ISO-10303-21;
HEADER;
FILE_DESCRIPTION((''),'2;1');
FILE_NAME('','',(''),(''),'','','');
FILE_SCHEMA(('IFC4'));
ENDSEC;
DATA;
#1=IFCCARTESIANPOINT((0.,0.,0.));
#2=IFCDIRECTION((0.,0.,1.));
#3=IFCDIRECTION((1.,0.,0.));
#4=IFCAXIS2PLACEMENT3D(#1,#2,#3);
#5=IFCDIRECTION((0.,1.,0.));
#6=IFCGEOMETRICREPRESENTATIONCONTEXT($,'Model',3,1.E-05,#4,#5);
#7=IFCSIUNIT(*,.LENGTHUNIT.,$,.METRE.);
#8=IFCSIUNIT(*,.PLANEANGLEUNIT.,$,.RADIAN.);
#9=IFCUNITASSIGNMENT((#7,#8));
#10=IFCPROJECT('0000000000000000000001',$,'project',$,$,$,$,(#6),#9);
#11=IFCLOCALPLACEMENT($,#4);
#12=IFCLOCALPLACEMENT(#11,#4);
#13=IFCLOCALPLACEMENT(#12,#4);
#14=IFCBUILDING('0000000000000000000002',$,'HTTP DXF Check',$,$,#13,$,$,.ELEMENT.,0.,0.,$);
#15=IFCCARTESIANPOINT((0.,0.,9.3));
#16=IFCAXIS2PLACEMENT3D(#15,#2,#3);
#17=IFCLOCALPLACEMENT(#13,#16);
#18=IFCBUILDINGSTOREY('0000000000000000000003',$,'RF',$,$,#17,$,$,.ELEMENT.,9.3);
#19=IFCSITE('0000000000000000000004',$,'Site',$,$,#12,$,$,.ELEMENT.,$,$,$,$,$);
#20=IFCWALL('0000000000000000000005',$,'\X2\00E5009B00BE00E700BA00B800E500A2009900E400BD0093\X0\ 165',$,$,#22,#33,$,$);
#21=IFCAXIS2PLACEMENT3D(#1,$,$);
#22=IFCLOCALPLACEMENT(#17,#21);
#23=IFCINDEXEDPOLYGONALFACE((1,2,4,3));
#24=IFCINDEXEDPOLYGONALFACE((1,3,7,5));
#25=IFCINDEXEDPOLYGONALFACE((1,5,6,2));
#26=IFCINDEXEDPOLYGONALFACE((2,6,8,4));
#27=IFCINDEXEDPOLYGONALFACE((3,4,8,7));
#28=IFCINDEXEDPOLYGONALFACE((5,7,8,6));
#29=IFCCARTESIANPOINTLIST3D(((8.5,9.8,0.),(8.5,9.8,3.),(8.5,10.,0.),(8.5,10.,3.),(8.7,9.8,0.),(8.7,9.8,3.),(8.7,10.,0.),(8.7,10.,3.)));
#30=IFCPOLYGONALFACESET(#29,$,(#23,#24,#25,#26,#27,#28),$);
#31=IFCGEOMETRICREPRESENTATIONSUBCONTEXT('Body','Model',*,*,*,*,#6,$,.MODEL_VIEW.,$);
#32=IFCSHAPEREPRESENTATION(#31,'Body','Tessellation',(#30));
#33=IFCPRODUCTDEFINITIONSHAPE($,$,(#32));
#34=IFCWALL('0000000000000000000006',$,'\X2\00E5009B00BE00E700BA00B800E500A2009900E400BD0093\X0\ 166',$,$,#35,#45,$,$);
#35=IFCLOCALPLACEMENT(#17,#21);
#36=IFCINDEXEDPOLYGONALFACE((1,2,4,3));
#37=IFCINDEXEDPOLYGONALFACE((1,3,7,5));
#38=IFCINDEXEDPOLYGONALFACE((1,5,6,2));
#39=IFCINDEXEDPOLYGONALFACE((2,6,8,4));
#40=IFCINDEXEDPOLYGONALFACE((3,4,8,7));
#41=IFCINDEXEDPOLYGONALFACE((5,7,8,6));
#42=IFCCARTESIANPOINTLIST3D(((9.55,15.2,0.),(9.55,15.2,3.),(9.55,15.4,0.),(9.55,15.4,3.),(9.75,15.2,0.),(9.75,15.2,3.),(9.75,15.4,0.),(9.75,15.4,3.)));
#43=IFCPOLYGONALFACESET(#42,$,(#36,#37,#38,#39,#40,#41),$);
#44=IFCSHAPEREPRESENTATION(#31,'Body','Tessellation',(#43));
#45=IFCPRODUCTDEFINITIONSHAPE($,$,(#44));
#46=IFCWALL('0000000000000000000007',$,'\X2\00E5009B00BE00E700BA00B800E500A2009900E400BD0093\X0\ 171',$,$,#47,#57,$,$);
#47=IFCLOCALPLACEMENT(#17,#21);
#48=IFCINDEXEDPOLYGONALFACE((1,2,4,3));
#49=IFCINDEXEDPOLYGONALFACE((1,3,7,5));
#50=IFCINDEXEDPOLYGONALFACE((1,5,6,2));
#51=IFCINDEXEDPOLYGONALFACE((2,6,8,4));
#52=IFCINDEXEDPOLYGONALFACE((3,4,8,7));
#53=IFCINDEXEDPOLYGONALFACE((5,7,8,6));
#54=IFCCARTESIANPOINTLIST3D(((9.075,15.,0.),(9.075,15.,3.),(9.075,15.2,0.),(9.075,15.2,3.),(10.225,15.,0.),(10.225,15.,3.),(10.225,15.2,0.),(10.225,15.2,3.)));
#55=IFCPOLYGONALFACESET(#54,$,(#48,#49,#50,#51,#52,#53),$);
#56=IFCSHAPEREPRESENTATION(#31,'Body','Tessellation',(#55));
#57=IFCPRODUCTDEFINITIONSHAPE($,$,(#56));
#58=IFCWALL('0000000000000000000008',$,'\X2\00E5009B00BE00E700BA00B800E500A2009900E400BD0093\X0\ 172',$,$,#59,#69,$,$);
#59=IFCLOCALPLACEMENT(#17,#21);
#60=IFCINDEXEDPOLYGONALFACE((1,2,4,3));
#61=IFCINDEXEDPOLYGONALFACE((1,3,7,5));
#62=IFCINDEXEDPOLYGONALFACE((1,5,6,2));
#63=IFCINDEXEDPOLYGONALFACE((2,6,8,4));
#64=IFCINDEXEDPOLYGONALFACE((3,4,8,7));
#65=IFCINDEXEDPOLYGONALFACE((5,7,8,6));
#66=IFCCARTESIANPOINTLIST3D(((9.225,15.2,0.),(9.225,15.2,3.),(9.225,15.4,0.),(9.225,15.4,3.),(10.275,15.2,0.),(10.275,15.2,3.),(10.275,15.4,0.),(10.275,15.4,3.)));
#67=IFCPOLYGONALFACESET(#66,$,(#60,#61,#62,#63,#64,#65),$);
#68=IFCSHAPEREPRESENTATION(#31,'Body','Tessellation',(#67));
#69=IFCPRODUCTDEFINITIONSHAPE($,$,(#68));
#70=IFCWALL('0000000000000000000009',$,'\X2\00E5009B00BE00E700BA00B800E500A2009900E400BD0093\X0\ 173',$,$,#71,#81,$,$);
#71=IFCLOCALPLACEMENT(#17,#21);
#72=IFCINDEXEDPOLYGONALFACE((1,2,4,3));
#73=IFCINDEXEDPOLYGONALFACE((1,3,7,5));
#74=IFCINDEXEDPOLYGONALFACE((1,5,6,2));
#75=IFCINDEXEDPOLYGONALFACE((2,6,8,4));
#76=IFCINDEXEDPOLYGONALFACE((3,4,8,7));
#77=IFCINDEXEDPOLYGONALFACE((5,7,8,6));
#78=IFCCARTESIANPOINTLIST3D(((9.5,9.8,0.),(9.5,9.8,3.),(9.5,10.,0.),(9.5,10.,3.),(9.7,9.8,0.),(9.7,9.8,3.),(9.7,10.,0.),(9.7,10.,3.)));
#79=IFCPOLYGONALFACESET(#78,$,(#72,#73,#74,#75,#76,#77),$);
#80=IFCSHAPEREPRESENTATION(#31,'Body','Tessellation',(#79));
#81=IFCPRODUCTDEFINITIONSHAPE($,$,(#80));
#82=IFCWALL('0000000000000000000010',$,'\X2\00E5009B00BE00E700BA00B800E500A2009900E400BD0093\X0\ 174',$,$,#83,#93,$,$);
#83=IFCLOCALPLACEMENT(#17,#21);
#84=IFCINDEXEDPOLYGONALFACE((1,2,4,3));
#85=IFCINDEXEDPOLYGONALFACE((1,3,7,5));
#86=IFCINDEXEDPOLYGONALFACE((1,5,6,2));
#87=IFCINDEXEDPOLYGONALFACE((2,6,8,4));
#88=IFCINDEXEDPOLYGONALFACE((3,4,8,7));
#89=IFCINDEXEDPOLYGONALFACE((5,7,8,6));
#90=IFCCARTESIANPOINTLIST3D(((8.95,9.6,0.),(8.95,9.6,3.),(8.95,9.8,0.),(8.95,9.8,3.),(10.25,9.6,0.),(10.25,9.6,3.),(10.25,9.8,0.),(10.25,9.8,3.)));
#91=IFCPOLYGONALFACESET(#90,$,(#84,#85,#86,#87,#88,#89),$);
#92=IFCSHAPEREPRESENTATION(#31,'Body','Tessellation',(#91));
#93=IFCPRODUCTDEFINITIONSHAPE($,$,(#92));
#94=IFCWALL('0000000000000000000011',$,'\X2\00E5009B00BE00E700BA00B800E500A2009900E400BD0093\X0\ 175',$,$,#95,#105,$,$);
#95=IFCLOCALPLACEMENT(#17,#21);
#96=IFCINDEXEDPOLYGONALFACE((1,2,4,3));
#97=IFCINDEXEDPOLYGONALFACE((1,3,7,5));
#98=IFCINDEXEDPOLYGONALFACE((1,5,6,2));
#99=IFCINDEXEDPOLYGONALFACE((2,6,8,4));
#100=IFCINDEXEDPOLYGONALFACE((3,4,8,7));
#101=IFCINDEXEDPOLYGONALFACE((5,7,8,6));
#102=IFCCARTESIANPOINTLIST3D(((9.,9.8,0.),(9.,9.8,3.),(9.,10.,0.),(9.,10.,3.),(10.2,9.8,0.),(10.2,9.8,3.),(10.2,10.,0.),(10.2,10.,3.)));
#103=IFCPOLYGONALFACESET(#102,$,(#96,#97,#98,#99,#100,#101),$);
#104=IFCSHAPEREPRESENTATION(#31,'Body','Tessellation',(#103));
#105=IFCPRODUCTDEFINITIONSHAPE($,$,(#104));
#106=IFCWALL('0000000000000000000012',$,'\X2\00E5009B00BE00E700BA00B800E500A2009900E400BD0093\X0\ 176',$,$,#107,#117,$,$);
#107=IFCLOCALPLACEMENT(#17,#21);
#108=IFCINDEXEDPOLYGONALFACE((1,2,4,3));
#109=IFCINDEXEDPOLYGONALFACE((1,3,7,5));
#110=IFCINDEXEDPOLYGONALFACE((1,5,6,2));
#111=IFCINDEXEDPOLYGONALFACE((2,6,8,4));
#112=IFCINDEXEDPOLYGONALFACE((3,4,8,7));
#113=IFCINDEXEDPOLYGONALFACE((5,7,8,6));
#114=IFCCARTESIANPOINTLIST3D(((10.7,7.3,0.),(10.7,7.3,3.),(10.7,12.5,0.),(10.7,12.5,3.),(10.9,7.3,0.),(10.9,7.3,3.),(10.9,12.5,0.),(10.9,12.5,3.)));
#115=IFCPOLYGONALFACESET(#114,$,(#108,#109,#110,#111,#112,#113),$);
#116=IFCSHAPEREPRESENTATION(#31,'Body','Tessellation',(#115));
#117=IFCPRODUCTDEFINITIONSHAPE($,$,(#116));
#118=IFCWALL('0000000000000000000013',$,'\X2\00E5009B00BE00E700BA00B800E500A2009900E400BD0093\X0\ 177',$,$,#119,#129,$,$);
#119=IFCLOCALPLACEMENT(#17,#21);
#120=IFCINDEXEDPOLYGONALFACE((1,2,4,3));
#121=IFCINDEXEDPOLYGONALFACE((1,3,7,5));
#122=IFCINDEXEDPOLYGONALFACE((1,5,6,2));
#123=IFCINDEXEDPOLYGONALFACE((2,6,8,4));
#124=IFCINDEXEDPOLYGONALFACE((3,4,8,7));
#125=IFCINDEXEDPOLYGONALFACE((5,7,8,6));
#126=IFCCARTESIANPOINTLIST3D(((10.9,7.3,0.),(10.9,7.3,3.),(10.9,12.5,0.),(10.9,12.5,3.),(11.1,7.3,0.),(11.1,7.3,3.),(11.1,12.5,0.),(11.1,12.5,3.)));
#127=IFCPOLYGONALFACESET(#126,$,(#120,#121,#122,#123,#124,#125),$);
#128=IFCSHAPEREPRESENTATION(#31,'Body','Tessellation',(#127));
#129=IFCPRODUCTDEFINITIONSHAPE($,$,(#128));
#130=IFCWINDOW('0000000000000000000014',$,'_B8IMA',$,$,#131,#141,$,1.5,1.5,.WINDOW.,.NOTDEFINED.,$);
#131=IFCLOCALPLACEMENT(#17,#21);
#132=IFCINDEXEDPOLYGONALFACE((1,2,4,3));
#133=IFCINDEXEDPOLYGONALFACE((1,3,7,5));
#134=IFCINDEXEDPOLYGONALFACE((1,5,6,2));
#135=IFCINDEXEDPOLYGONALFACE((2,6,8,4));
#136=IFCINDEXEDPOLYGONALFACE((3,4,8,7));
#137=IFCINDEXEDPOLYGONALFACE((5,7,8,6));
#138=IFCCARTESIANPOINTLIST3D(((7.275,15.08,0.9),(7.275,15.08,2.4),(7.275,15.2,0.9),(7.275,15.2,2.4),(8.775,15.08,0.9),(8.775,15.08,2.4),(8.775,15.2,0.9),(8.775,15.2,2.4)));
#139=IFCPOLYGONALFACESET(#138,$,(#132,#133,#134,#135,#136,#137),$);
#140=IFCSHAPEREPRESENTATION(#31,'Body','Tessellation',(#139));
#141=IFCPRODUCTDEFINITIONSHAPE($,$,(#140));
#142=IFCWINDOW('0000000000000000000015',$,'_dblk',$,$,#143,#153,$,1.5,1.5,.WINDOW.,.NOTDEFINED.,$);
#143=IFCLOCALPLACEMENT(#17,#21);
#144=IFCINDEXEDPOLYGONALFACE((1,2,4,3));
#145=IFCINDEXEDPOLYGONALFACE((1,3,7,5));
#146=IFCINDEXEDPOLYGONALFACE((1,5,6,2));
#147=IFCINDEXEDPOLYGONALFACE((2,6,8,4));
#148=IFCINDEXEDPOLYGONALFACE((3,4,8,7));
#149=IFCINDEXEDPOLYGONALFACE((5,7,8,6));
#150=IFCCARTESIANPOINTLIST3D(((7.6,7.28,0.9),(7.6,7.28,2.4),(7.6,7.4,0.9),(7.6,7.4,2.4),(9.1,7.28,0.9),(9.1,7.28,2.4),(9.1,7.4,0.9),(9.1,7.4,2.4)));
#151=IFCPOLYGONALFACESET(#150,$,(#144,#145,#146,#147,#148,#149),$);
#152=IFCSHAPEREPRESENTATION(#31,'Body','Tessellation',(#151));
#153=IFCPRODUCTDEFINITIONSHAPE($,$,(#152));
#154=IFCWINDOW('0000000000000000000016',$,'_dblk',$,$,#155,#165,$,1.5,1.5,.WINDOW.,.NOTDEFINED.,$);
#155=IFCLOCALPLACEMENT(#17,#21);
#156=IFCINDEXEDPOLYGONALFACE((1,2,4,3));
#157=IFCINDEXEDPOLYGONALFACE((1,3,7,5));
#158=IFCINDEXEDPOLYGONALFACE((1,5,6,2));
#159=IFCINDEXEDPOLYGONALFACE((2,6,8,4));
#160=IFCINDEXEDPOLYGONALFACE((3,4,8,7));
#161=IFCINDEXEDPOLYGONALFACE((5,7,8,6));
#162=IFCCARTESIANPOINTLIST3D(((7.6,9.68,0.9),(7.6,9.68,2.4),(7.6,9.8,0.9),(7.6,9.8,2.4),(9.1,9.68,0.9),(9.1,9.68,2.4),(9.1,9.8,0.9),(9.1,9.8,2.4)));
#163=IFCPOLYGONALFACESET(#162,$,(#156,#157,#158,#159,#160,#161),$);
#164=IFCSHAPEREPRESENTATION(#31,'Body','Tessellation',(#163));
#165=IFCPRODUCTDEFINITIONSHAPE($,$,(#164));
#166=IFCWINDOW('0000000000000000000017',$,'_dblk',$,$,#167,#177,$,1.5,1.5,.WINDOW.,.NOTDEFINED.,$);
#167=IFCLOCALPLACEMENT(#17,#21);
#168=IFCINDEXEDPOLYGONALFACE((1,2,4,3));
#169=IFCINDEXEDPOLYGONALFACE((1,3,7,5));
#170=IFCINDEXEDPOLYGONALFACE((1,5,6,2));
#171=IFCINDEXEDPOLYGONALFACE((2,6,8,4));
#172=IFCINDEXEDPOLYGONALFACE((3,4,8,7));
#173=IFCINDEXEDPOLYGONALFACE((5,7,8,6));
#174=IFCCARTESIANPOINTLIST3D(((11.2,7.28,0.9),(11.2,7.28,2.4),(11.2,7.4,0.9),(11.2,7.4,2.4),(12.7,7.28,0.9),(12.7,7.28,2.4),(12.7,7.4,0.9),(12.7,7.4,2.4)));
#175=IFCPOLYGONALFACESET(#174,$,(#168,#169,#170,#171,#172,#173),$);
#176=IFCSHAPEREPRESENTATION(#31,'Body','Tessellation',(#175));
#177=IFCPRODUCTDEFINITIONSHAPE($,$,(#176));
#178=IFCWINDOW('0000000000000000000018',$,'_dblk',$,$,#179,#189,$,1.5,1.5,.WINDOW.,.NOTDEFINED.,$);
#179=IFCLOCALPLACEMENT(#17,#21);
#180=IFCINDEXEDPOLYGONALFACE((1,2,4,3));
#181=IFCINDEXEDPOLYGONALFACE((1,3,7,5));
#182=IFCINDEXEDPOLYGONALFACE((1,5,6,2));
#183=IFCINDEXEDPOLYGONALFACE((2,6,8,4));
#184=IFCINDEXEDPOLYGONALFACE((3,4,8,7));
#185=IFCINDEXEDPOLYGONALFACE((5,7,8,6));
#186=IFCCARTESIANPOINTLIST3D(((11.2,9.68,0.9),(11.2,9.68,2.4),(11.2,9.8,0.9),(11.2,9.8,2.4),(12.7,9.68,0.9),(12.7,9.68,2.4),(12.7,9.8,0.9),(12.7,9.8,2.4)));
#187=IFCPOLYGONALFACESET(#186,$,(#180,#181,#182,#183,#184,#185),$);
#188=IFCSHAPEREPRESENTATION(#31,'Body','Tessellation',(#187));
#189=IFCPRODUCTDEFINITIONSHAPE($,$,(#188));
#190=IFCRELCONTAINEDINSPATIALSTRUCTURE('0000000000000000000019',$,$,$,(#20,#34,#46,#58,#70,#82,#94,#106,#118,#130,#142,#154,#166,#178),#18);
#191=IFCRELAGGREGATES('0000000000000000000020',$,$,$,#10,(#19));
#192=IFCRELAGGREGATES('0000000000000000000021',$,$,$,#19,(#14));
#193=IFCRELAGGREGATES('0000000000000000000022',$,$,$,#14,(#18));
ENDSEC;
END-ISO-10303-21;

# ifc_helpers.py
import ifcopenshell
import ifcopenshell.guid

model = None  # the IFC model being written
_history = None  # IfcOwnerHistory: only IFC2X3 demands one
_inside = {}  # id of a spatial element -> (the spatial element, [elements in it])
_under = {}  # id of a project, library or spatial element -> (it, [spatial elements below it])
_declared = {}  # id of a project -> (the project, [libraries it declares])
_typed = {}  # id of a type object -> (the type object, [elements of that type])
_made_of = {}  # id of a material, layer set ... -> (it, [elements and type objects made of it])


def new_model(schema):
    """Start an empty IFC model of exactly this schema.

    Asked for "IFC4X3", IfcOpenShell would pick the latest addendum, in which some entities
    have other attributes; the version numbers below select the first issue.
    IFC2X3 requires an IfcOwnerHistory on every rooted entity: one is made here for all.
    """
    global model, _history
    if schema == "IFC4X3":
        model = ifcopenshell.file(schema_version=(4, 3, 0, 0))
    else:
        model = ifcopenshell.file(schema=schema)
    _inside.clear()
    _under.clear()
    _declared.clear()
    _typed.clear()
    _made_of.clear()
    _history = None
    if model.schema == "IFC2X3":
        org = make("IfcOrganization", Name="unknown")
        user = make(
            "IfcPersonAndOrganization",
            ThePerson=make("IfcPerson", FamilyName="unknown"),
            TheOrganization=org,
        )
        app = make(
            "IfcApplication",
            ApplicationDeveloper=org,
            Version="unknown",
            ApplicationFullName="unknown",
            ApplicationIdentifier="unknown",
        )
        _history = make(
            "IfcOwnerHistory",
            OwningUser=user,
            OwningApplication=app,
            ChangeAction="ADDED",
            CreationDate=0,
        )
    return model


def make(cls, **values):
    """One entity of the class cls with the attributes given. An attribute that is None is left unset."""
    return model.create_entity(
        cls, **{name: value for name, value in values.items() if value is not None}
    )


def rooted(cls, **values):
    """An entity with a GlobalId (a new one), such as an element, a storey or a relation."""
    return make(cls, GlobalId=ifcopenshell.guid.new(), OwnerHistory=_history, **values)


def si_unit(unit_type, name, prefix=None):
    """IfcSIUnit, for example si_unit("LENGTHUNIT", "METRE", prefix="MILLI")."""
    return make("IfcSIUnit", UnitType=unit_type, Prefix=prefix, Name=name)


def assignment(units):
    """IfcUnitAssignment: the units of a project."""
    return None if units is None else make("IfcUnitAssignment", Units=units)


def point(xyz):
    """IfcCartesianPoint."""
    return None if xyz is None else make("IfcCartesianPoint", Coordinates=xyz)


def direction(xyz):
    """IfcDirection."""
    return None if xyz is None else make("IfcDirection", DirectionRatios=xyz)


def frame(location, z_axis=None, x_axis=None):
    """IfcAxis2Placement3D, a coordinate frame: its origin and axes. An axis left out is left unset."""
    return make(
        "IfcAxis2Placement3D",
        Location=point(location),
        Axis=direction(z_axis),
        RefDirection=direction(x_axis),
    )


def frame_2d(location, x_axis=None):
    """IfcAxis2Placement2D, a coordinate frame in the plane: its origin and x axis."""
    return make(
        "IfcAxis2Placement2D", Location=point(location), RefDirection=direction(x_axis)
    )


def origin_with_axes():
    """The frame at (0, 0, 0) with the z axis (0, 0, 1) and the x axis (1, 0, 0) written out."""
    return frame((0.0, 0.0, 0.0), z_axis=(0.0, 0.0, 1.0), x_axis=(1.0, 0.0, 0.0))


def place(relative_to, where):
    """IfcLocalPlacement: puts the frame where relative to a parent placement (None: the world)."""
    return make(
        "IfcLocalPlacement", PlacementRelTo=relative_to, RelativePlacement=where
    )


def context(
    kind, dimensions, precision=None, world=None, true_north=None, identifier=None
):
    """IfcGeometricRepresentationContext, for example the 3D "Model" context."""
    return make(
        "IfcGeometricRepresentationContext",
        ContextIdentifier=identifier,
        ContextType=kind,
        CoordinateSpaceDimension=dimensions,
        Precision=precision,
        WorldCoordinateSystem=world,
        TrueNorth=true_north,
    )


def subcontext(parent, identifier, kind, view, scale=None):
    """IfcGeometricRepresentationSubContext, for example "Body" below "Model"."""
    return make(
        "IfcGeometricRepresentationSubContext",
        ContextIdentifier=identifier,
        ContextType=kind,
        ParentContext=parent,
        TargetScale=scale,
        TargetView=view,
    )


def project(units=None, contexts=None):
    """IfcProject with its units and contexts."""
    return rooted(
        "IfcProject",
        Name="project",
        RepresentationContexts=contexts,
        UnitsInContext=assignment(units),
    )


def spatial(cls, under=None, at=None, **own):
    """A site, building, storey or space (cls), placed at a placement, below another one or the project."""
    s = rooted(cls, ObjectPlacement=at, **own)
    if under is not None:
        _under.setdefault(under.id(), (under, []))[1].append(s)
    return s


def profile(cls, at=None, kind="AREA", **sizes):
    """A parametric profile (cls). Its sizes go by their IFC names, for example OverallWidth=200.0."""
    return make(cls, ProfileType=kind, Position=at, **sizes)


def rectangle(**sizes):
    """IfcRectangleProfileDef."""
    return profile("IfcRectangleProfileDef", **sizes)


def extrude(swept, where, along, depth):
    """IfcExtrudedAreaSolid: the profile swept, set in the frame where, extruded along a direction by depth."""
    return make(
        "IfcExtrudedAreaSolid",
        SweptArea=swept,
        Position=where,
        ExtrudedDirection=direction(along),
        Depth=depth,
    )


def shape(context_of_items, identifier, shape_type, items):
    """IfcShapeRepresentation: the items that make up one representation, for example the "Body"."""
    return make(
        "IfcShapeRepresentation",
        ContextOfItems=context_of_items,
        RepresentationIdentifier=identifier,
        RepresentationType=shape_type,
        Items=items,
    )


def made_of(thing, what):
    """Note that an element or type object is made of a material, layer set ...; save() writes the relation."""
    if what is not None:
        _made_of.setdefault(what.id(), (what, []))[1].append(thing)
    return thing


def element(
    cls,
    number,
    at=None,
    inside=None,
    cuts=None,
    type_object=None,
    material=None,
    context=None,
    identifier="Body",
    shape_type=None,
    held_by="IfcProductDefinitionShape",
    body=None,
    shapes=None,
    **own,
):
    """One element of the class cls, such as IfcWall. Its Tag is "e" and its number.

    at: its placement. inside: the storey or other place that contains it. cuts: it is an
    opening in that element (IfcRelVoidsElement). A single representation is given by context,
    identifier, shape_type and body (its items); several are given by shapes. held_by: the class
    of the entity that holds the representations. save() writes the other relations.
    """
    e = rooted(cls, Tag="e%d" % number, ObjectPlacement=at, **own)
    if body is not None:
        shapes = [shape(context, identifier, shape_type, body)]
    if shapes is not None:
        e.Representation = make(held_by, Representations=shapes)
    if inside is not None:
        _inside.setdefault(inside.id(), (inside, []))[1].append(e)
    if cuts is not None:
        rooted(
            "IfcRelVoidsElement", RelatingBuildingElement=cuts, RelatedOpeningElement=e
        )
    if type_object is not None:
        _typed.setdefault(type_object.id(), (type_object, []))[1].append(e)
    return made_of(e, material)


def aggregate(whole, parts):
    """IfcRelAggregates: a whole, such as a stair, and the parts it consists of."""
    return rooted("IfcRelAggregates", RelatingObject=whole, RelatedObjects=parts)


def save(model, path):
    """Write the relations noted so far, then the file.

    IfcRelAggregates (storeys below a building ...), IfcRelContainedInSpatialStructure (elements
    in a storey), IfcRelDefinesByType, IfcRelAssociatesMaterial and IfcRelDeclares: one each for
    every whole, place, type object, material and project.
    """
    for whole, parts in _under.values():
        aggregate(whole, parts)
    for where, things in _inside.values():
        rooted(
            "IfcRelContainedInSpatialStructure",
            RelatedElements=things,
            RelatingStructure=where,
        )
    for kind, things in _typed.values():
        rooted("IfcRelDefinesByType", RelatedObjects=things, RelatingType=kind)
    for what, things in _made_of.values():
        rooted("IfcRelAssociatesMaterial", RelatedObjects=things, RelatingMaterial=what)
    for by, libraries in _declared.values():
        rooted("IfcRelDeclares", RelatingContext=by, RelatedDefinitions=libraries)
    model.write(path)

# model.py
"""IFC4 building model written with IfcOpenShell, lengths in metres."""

from ifc_helpers import new_model, si_unit, direction, frame, frame_2d, origin_with_axes, place, context, subcontext, project, spatial, rectangle, extrude, element, save


model = new_model("IFC4")

# Units and contexts
model_context = context("Model", 3, precision=1e-05, world=origin_with_axes(), true_north=direction((0.0, 1.0, 0.0)))
body_context = subcontext(model_context, "Body", "Model", "MODEL_VIEW")
ifc_project = project(units=[si_unit("LENGTHUNIT", "METRE"), si_unit("PLANEANGLEUNIT", "RADIAN")], contexts=[model_context])

# Site, building, storey
placement = place(None, origin_with_axes())
site_placement = place(placement, origin_with_axes())
site = spatial("IfcSite", under=ifc_project, at=site_placement, Name="Site", CompositionType="ELEMENT")
building_placement = place(site_placement, origin_with_axes())
building = spatial("IfcBuilding", under=site, at=building_placement, Name="HTTP DXF Check", CompositionType="ELEMENT", ElevationOfRefHeight=0.0, ElevationOfTerrain=0.0)
storey_placement = place(building_placement, frame((0.0, 0.0, 9.3), z_axis=(0.0, 0.0, 1.0), x_axis=(1.0, 0.0, 0.0)))
storey = spatial("IfcBuildingStorey", under=building, at=storey_placement, Name="RF", CompositionType="ELEMENT", Elevation=9.3)

# Walls
for number, where, z_axis, x_axis, name in (
    (1, (8.6, 9.9, 0.0), (0.0, 0.0, 1.0), (0.0, -1.0, 0.0), "å\u009b¾çº¸å¢\u0099ä½\u0093 165"),
    (2, (9.65, 15.3, 0.0), (0.0, 0.0, 1.0), (0.0, -1.0, 0.0), "å\u009b¾çº¸å¢\u0099ä½\u0093 166"),
):
    element("IfcWall", number, at=place(storey_placement, frame(where, z_axis=z_axis, x_axis=x_axis)), inside=storey, Name=name, context=body_context, shape_type="SweptSolid", body=[
        extrude(rectangle(XDim=0.2, YDim=0.2, at=frame_2d((0.0, 0.0), x_axis=(1.0, 0.0, 0.0))), frame((0.0, 0.0, 0.0), z_axis=(0.0, 0.0, 1.0)), (0.0, 0.0, 1.0), 3.0),
    ])
wall_1_placement = place(storey_placement, frame((9.65, 15.1, 0.0), z_axis=(0.0, 0.0, 1.0), x_axis=(1.0, 0.0, 0.0)))
element("IfcWall", 3, at=wall_1_placement, inside=storey, Name="å\u009b¾çº¸å¢\u0099ä½\u0093 171", context=body_context, shape_type="SweptSolid", body=[
    extrude(rectangle(XDim=1.15, YDim=0.2, at=frame_2d((0.0, 0.0), x_axis=(1.0, 0.0, 0.0))), frame((0.0, 0.0, 0.0), z_axis=(0.0, 0.0, 1.0)), (0.0, 0.0, 1.0), 3.0),
])
wall_2_placement = place(storey_placement, frame((9.75, 15.3, 0.0), z_axis=(0.0, 0.0, 1.0), x_axis=(1.0, 0.0, 0.0)))
element("IfcWall", 4, at=wall_2_placement, inside=storey, Name="å\u009b¾çº¸å¢\u0099ä½\u0093 172", context=body_context, shape_type="SweptSolid", body=[
    extrude(rectangle(XDim=1.05, YDim=0.2, at=frame_2d((0.0, 0.0), x_axis=(1.0, 0.0, 0.0))), frame((0.0, 0.0, 0.0), z_axis=(0.0, 0.0, 1.0)), (0.0, 0.0, 1.0), 3.0),
])
wall_3_placement = place(storey_placement, frame((9.6, 9.9, 0.0), z_axis=(0.0, 0.0, 1.0), x_axis=(0.0, -1.0, 0.0)))
element("IfcWall", 5, at=wall_3_placement, inside=storey, Name="å\u009b¾çº¸å¢\u0099ä½\u0093 173", context=body_context, shape_type="SweptSolid", body=[
    extrude(rectangle(XDim=0.2, YDim=0.2, at=frame_2d((0.0, 0.0), x_axis=(1.0, 0.0, 0.0))), frame((0.0, 0.0, 0.0), z_axis=(0.0, 0.0, 1.0)), (0.0, 0.0, 1.0), 3.0),
])
wall_4_placement = place(storey_placement, frame((9.6, 9.7, 0.0), z_axis=(0.0, 0.0, 1.0), x_axis=(1.0, 0.0, 0.0)))
element("IfcWall", 6, at=wall_4_placement, inside=storey, Name="å\u009b¾çº¸å¢\u0099ä½\u0093 174", context=body_context, shape_type="SweptSolid", body=[
    extrude(rectangle(XDim=1.3, YDim=0.2, at=frame_2d((0.0, 0.0), x_axis=(1.0, 0.0, 0.0))), frame((0.0, 0.0, 0.0), z_axis=(0.0, 0.0, 1.0)), (0.0, 0.0, 1.0), 3.0),
])
wall_5_placement = place(storey_placement, frame((9.6, 9.9, 0.0), z_axis=(0.0, 0.0, 1.0), x_axis=(1.0, 0.0, 0.0)))
element("IfcWall", 7, at=wall_5_placement, inside=storey, Name="å\u009b¾çº¸å¢\u0099ä½\u0093 175", context=body_context, shape_type="SweptSolid", body=[
    extrude(rectangle(XDim=1.2, YDim=0.2, at=frame_2d((0.0, 0.0), x_axis=(1.0, 0.0, 0.0))), frame((0.0, 0.0, 0.0), z_axis=(0.0, 0.0, 1.0)), (0.0, 0.0, 1.0), 3.0),
])
for number, where, z_axis, x_axis, name in (
    (8, (10.8, 9.9, 0.0), (0.0, 0.0, 1.0), (0.0, 1.0, 0.0), "å\u009b¾çº¸å¢\u0099ä½\u0093 176"),
    (9, (11.0, 9.9, 0.0), (0.0, 0.0, 1.0), (0.0, 1.0, 0.0), "å\u009b¾çº¸å¢\u0099ä½\u0093 177"),
):
    element("IfcWall", number, at=place(storey_placement, frame(where, z_axis=z_axis, x_axis=x_axis)), inside=storey, Name=name, context=body_context, shape_type="SweptSolid", body=[
        extrude(rectangle(XDim=5.2, YDim=0.2, at=frame_2d((0.0, 0.0), x_axis=(1.0, 0.0, 0.0))), frame((0.0, 0.0, 0.0), z_axis=(0.0, 0.0, 1.0)), (0.0, 0.0, 1.0), 3.0),
    ])

# Windows
for number, where, z_axis, x_axis, name in (
    (10, (8.025, 15.14, 0.9), (0.0, 0.0, 1.0), (1.0, 0.0, 0.0), "_B8IMA"),
    (11, (8.35, 7.34, 0.9), (0.0, 0.0, 1.0), (1.0, 0.0, 0.0), "_dblk"),
    (12, (8.35, 9.74, 0.9), (0.0, 0.0, 1.0), (1.0, 0.0, 0.0), "_dblk"),
    (13, (11.95, 7.34, 0.9), (0.0, 0.0, 1.0), (1.0, 0.0, 0.0), "_dblk"),
    (14, (11.95, 9.74, 0.9), (0.0, 0.0, 1.0), (1.0, 0.0, 0.0), "_dblk"),
):
    element("IfcWindow", number, at=place(storey_placement, frame(where, z_axis=z_axis, x_axis=x_axis)), inside=storey, Name=name, OverallHeight=1.5, OverallWidth=1.5, PartitioningType="NOTDEFINED", PredefinedType="WINDOW", context=body_context, shape_type="SweptSolid", body=[
        extrude(rectangle(XDim=1.5, YDim=0.12, at=frame_2d((0.0, 0.0), x_axis=(1.0, 0.0, 0.0))), frame((0.0, 0.0, 0.0), z_axis=(0.0, 0.0, 1.0)), (0.0, 0.0, 1.0), 1.5),
    ])

save(model, "model.ifc")
